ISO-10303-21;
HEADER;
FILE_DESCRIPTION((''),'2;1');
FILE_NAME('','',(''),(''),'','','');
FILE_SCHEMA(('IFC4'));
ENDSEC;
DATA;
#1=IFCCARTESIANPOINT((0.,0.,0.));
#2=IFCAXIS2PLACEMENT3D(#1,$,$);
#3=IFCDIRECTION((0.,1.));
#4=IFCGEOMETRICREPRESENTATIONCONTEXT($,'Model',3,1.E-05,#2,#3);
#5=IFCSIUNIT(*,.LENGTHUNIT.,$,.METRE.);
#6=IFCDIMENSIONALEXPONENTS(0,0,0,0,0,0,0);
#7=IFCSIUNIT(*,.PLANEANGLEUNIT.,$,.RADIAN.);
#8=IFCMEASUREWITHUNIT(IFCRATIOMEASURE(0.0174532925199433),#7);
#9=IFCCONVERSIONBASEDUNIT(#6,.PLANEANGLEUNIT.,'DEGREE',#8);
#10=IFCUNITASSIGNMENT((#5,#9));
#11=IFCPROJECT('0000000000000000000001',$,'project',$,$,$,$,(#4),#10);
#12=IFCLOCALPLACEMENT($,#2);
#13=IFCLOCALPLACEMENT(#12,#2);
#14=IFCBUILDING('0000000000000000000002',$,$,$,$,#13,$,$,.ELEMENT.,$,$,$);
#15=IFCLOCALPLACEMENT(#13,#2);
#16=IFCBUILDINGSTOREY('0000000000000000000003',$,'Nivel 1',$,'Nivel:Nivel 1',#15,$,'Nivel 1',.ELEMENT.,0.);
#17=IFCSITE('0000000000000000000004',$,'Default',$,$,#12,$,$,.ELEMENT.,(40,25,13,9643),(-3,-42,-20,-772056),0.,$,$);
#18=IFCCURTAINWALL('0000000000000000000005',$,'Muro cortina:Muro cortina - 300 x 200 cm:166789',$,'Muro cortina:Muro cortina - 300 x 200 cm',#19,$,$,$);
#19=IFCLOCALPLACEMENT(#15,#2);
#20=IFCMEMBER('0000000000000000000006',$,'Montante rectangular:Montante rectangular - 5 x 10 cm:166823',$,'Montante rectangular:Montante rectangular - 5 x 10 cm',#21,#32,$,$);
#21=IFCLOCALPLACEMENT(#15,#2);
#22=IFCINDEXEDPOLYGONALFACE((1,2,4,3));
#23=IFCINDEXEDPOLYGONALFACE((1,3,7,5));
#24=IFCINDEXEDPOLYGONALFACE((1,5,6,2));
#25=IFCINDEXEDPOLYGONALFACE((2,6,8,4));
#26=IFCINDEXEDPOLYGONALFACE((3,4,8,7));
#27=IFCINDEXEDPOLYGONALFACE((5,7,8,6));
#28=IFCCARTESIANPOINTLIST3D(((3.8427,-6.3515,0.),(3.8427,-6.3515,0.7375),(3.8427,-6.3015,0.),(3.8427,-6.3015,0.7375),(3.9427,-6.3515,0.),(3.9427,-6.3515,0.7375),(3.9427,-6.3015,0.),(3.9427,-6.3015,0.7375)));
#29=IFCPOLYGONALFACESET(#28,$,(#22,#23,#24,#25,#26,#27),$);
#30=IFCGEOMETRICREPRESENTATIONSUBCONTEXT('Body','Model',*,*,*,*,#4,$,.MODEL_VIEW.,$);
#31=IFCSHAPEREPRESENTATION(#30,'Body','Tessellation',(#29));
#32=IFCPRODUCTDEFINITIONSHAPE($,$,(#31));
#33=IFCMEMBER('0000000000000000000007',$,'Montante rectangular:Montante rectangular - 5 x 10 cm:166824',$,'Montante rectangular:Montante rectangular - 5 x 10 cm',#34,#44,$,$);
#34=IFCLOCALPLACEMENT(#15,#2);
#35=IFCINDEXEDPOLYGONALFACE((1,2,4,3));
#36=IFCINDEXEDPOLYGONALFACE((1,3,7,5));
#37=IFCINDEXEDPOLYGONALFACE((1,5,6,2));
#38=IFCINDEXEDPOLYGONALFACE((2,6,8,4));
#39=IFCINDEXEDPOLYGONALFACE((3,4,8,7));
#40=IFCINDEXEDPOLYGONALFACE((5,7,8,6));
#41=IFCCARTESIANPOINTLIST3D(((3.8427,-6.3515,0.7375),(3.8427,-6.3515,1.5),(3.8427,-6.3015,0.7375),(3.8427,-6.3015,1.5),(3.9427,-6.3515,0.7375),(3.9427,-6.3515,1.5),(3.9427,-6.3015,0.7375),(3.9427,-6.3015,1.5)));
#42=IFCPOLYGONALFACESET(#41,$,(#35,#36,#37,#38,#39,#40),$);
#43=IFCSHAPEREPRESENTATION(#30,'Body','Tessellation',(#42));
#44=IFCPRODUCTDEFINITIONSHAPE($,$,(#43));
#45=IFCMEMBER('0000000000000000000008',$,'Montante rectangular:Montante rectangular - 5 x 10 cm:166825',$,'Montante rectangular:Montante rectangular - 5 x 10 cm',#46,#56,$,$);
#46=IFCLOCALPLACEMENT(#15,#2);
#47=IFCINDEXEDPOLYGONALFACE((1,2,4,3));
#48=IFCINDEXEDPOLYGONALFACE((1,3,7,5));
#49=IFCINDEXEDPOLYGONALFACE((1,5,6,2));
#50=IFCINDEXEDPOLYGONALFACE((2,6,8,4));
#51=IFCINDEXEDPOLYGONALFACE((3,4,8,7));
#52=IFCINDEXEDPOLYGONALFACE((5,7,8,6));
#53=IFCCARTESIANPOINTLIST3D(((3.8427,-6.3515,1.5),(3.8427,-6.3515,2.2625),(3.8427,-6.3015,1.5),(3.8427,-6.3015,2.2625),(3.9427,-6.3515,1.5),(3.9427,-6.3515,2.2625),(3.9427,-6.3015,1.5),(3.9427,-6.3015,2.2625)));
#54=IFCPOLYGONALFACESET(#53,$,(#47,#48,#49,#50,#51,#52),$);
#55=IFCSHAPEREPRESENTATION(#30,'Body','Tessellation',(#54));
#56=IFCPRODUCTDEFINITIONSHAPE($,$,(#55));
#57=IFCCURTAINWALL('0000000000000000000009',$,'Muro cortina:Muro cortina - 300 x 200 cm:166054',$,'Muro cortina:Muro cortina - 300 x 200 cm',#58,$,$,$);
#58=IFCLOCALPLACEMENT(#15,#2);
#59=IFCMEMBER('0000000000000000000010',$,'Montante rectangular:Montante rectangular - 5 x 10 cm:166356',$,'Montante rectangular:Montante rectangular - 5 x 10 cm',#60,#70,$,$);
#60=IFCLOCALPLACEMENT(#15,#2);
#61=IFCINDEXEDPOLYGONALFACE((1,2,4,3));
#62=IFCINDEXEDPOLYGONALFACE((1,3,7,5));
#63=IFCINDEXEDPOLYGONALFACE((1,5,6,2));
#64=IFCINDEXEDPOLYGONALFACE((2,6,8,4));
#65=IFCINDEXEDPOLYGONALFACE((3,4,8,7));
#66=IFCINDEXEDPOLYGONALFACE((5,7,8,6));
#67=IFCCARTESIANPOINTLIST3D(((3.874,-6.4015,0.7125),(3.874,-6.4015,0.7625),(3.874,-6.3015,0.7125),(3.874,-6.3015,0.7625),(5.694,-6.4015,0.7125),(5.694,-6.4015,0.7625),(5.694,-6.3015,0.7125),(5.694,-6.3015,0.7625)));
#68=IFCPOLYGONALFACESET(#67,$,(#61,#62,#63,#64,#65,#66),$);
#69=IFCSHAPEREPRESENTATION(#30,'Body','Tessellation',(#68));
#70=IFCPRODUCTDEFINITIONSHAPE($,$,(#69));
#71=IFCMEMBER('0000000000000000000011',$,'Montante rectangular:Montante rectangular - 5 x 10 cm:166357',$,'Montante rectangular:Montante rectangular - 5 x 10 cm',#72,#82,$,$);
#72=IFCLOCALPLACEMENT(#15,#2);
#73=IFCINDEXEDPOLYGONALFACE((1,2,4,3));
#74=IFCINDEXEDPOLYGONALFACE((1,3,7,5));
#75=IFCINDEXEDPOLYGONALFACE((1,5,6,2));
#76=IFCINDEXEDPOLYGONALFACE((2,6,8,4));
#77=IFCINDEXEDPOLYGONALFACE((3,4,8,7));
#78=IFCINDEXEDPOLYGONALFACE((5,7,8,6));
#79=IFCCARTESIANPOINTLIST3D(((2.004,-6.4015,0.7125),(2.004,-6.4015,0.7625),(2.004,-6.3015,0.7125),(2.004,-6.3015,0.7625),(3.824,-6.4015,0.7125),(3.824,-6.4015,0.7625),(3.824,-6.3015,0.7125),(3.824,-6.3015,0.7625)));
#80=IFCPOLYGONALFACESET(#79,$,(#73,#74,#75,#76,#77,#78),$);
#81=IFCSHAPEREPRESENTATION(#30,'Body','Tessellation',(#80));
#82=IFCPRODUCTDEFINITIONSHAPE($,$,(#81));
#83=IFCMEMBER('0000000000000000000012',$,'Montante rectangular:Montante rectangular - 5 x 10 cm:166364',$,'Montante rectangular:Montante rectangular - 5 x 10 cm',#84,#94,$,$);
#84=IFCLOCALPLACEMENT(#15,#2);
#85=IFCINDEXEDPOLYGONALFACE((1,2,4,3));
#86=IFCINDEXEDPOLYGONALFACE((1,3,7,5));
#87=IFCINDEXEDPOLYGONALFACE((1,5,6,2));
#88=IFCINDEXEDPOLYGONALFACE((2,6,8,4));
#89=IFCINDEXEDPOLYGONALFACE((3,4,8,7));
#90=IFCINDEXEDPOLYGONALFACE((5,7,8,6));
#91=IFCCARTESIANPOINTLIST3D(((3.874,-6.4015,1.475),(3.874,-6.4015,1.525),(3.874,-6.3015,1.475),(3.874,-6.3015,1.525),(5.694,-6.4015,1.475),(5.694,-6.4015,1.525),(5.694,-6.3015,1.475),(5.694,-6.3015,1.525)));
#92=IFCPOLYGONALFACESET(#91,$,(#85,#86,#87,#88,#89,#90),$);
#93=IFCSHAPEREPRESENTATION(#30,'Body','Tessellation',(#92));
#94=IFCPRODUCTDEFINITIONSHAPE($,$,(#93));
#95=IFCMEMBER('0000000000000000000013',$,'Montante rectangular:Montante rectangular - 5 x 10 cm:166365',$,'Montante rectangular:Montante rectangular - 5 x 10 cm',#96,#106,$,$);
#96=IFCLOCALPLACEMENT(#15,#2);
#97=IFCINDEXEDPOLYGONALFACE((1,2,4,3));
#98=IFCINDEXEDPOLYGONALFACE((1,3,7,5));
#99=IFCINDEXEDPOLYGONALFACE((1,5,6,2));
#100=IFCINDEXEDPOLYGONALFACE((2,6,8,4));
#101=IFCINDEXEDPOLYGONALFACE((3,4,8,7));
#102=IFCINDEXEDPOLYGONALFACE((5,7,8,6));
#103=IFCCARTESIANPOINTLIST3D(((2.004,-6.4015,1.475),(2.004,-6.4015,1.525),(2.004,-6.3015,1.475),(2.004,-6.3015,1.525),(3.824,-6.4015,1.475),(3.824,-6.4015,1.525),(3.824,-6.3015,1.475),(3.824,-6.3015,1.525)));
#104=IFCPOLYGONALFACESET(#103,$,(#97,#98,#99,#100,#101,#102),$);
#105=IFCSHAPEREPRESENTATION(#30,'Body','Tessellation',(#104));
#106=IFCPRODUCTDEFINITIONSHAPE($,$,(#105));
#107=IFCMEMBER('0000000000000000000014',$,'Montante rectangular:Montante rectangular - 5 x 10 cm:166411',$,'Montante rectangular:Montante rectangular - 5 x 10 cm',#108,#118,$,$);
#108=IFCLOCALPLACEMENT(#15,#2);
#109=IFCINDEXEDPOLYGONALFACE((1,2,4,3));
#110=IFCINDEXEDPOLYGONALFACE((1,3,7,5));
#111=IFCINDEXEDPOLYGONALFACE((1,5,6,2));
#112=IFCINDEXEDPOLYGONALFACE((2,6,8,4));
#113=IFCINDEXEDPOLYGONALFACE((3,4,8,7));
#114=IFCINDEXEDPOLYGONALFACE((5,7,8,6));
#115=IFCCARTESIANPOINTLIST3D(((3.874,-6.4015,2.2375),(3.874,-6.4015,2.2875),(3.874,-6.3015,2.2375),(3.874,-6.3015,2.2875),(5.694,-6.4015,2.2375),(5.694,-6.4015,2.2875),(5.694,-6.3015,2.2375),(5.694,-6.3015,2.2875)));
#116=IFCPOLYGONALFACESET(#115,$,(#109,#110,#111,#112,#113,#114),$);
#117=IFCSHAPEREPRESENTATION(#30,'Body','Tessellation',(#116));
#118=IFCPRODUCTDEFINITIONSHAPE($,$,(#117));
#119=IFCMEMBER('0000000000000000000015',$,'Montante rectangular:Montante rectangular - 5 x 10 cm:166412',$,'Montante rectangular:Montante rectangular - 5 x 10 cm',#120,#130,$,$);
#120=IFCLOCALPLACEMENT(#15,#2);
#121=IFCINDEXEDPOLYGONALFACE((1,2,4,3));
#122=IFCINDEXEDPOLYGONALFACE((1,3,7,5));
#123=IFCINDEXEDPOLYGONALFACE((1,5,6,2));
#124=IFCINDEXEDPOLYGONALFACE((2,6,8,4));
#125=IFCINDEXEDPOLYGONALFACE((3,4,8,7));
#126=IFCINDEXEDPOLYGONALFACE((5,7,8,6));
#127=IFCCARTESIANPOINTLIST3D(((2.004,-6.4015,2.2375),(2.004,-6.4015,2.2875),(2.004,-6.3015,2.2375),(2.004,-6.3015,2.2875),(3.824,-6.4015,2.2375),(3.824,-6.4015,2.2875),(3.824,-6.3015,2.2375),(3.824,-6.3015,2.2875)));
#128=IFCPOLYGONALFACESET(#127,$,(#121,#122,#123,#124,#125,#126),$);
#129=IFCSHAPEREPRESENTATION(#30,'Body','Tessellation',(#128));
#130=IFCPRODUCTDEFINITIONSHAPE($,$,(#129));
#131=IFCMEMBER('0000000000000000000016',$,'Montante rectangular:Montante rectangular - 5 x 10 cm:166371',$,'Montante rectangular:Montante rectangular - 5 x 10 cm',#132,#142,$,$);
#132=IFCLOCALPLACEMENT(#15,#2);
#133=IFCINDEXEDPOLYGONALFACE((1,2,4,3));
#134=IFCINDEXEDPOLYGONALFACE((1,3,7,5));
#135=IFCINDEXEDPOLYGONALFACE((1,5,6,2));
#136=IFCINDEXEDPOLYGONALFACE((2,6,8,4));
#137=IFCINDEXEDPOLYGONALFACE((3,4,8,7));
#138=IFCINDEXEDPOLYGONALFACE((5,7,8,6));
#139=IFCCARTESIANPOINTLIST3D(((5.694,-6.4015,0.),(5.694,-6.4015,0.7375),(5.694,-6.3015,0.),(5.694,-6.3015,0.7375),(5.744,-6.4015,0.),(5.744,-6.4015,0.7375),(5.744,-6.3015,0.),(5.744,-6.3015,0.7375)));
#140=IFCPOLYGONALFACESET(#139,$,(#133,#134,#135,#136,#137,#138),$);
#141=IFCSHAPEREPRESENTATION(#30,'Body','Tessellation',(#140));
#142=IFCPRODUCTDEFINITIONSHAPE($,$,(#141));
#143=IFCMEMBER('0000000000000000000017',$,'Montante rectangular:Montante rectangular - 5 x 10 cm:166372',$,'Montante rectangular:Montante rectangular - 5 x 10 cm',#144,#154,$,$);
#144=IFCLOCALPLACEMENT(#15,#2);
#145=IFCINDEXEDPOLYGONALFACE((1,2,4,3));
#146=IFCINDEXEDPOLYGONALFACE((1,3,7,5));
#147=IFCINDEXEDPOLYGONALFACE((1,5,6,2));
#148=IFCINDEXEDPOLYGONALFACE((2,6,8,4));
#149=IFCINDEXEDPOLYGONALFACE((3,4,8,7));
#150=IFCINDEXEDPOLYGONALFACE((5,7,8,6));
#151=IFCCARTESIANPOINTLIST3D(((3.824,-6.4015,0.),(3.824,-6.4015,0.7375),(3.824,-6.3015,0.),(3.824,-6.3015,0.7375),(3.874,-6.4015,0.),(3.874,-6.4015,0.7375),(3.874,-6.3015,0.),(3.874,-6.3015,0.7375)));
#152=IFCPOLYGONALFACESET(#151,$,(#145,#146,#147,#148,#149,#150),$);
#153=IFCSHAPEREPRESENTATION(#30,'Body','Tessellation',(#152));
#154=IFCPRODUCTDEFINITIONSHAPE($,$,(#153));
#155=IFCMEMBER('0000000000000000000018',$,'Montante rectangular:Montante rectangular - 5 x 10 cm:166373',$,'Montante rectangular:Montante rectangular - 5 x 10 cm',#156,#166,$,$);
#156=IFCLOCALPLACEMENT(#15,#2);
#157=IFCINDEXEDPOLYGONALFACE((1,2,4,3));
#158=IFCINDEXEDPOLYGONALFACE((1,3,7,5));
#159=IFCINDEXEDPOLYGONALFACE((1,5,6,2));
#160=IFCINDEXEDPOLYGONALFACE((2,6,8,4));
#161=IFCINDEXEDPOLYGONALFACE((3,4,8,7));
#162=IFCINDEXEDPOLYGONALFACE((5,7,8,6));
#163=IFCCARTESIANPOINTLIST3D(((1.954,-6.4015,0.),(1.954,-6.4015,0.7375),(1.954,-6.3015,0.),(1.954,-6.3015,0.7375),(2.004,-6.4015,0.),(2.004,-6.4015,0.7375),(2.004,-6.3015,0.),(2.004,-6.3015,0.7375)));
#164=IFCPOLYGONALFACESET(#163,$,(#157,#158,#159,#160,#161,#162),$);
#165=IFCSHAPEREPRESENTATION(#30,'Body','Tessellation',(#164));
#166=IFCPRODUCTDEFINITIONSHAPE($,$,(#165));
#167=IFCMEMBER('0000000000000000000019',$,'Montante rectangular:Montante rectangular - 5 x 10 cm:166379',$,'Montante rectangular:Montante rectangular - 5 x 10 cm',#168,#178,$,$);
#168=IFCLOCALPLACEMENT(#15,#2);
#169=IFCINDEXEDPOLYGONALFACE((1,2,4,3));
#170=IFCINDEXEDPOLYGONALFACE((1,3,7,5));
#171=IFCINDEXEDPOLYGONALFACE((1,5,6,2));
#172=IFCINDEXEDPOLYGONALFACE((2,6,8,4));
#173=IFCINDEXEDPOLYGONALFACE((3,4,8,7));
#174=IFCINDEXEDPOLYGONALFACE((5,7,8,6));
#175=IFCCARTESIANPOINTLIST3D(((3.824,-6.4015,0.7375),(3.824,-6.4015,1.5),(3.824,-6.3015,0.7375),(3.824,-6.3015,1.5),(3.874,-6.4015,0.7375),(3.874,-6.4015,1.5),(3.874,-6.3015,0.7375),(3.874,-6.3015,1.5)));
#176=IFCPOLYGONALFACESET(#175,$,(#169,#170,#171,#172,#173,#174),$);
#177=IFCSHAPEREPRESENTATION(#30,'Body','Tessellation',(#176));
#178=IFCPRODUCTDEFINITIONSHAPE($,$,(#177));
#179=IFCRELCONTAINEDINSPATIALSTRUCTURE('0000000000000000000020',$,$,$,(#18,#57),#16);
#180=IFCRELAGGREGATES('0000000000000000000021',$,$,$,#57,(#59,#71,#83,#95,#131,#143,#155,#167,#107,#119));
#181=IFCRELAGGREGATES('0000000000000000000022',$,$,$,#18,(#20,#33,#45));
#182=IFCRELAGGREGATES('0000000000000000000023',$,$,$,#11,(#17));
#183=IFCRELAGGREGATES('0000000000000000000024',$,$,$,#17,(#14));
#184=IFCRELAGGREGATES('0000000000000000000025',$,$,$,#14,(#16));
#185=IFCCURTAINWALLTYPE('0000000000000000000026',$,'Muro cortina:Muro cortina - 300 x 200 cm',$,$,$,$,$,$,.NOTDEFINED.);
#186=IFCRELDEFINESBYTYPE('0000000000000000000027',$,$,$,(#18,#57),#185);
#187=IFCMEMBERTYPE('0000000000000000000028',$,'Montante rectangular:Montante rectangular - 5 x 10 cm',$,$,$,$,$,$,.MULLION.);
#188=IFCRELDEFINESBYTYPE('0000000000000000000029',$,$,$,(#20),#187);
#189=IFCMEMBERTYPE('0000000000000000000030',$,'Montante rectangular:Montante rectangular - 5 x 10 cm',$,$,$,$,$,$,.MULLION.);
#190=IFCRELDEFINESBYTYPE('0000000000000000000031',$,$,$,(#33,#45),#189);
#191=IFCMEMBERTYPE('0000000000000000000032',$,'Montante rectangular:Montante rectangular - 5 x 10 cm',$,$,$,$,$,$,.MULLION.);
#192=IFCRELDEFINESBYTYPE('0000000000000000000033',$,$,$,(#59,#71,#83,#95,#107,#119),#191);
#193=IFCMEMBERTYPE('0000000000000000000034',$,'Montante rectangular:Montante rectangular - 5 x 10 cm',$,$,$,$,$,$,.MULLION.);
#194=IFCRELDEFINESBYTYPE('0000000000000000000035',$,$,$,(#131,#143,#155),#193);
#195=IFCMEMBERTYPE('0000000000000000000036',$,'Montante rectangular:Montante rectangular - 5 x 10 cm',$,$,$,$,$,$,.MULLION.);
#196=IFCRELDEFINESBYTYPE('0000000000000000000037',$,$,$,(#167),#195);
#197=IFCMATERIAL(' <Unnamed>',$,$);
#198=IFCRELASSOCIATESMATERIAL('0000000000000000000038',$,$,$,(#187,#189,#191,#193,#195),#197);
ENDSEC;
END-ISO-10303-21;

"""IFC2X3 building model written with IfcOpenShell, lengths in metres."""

from ifc_helpers import new_model, entity, si_unit, converted_unit, direction, frame, origin, origin_2d_with_axis, place, context, subcontext, project, spatial, rectangle, extrude, source, transform, mapped, material, type_object, type_shapes, element, aggregate, save


model = new_model("IFC2X3")

# Units and contexts
model_context = context("Model", 3, precision=1e-05, world=origin(), true_north=direction((0.0, 1.0)))
body_context = subcontext(model_context, "Body", "Model", "MODEL_VIEW")
ifc_project = project(units=[si_unit("LENGTHUNIT", "METRE"), converted_unit("PLANEANGLEUNIT", "DEGREE", entity("IfcRatioMeasure", 0.0174532925199433), si_unit("PLANEANGLEUNIT", "RADIAN"), dimensions=[0, 0, 0, 0, 0, 0, 0])], contexts=[model_context])

# Site, building, storey
site_placement = place(None, origin())
site = spatial("IfcSite", under=ifc_project, at=site_placement, Name="Default", CompositionType="ELEMENT", RefLatitude=(40, 25, 13, 9643), RefLongitude=(-3, -42, -20, -772056), RefElevation=0.0)
building_placement = place(site_placement, origin())
building = spatial("IfcBuilding", under=site, at=building_placement, CompositionType="ELEMENT")
storey_placement = place(building_placement, origin())
storey = spatial("IfcBuildingStorey", under=building, at=storey_placement, Name="Nivel 1", ObjectType="Nivel:Nivel 1", LongName="Nivel 1", CompositionType="ELEMENT", Elevation=0.0)

# Curtain walls, members
curtain_wall_type = type_object("IfcCurtainWallType", Name="Muro cortina:Muro cortina - 300 x 200 cm", PredefinedType="NOTDEFINED")
curtain_wall_1_placement = place(storey_placement, origin())
curtain_wall_1 = element("IfcCurtainWall", 1, at=curtain_wall_1_placement, inside=storey, type_object=curtain_wall_type, Name="Muro cortina:Muro cortina - 300 x 200 cm:166789", ObjectType="Muro cortina:Muro cortina - 300 x 200 cm")
ifc_material_1 = material(Name=" <Unnamed>")
member_type_1 = type_object("IfcMemberType", Name="Montante rectangular:Montante rectangular - 5 x 10 cm", PredefinedType="MULLION", material=ifc_material_1)
shared_shape_1 = source(origin(), body_context, "Body", "SweptSolid", [
    extrude(rectangle(XDim=0.1, YDim=0.05, at=origin_2d_with_axis()), frame((-0.025, 0.0, -0.7375), z_axis=(0.0, 0.0, 1.0), x_axis=(0.0, -1.0, 0.0)), (0.0, 0.0, 1.0), 0.7375),
])
type_shapes(member_type_1, [shared_shape_1])
member_1_placement = place(storey_placement, frame((3.8927, -6.3515, 0.0), z_axis=(0.0, 0.0, -1.0), x_axis=(0.0, -1.0, 0.0)))
member_1 = element("IfcMember", 2, at=member_1_placement, type_object=member_type_1, Name="Montante rectangular:Montante rectangular - 5 x 10 cm:166823", ObjectType="Montante rectangular:Montante rectangular - 5 x 10 cm", context=body_context, shape_type="MappedRepresentation", body=[
    mapped(shared_shape_1, transform((0.0, 0.0, 0.0), scale=1.0)),
])
member_type_2 = type_object("IfcMemberType", Name="Montante rectangular:Montante rectangular - 5 x 10 cm", PredefinedType="MULLION", material=ifc_material_1)
shared_shape_2 = source(origin(), body_context, "Body", "SweptSolid", [
    extrude(rectangle(XDim=0.1, YDim=0.05, at=origin_2d_with_axis()), frame((-0.025, 0.0, -0.7625), z_axis=(0.0, 0.0, 1.0), x_axis=(0.0, -1.0, 0.0)), (0.0, 0.0, 1.0), 0.7625),
])
type_shapes(member_type_2, [shared_shape_2])
member_2_placement = place(storey_placement, frame((3.8927, -6.3515, 0.7375), z_axis=(0.0, 0.0, -1.0), x_axis=(0.0, -1.0, 0.0)))
member_2 = element("IfcMember", 3, at=member_2_placement, type_object=member_type_2, Name="Montante rectangular:Montante rectangular - 5 x 10 cm:166824", ObjectType="Montante rectangular:Montante rectangular - 5 x 10 cm", context=body_context, shape_type="MappedRepresentation", body=[
    mapped(shared_shape_2, transform((0.0, 0.0, 0.0), scale=1.0)),
])
member_3_placement = place(storey_placement, frame((3.8927, -6.3515, 1.5), z_axis=(0.0, 0.0, -1.0), x_axis=(0.0, -1.0, 0.0)))
member_3 = element("IfcMember", 4, at=member_3_placement, type_object=member_type_2, Name="Montante rectangular:Montante rectangular - 5 x 10 cm:166825", ObjectType="Montante rectangular:Montante rectangular - 5 x 10 cm", context=body_context, shape_type="MappedRepresentation", body=[
    mapped(shared_shape_2, transform((0.0, 0.0, 0.0), scale=1.0)),
])
curtain_wall_2_placement = place(storey_placement, origin())
curtain_wall_2 = element("IfcCurtainWall", 5, at=curtain_wall_2_placement, inside=storey, type_object=curtain_wall_type, Name="Muro cortina:Muro cortina - 300 x 200 cm:166054", ObjectType="Muro cortina:Muro cortina - 300 x 200 cm")
member_type_3 = type_object("IfcMemberType", Name="Montante rectangular:Montante rectangular - 5 x 10 cm", PredefinedType="MULLION", material=ifc_material_1)
shared_shape_3 = source(origin(), body_context, "Body", "SweptSolid", [
    extrude(rectangle(XDim=0.1, YDim=0.05, at=origin_2d_with_axis()), frame((0.0, 0.0, -1.82), z_axis=(0.0, 0.0, 1.0), x_axis=(0.0, -1.0, 0.0)), (0.0, 0.0, 1.0), 1.82),
])
type_shapes(member_type_3, [shared_shape_3])
member_4_placement = place(storey_placement, frame((3.874, -6.3515, 0.7375), z_axis=(-1.0, 0.0, 0.0), x_axis=(0.0, 0.0, 1.0)))
member_4 = element("IfcMember", 6, at=member_4_placement, type_object=member_type_3, Name="Montante rectangular:Montante rectangular - 5 x 10 cm:166356", ObjectType="Montante rectangular:Montante rectangular - 5 x 10 cm", context=body_context, shape_type="MappedRepresentation", body=[
    mapped(shared_shape_3, transform((0.0, 0.0, 0.0), scale=1.0)),
])
member_5_placement = place(storey_placement, frame((2.004, -6.3515, 0.7375), z_axis=(-1.0, 0.0, 0.0), x_axis=(0.0, 0.0, 1.0)))
member_5 = element("IfcMember", 7, at=member_5_placement, type_object=member_type_3, Name="Montante rectangular:Montante rectangular - 5 x 10 cm:166357", ObjectType="Montante rectangular:Montante rectangular - 5 x 10 cm", context=body_context, shape_type="MappedRepresentation", body=[
    mapped(shared_shape_3, transform((0.0, 0.0, 0.0), scale=1.0)),
])
member_6_placement = place(storey_placement, frame((3.874, -6.3515, 1.5), z_axis=(-1.0, 0.0, 0.0), x_axis=(0.0, 0.0, 1.0)))
member_6 = element("IfcMember", 8, at=member_6_placement, type_object=member_type_3, Name="Montante rectangular:Montante rectangular - 5 x 10 cm:166364", ObjectType="Montante rectangular:Montante rectangular - 5 x 10 cm", context=body_context, shape_type="MappedRepresentation", body=[
    mapped(shared_shape_3, transform((0.0, 0.0, 0.0), scale=1.0)),
])
member_7_placement = place(storey_placement, frame((2.004, -6.3515, 1.5), z_axis=(-1.0, 0.0, 0.0), x_axis=(0.0, 0.0, 1.0)))
member_7 = element("IfcMember", 9, at=member_7_placement, type_object=member_type_3, Name="Montante rectangular:Montante rectangular - 5 x 10 cm:166365", ObjectType="Montante rectangular:Montante rectangular - 5 x 10 cm", context=body_context, shape_type="MappedRepresentation", body=[
    mapped(shared_shape_3, transform((0.0, 0.0, 0.0), scale=1.0)),
])
member_8_placement = place(storey_placement, frame((3.874, -6.3515, 2.2625), z_axis=(-1.0, 0.0, 0.0), x_axis=(0.0, 0.0, 1.0)))
member_8 = element("IfcMember", 10, at=member_8_placement, type_object=member_type_3, Name="Montante rectangular:Montante rectangular - 5 x 10 cm:166411", ObjectType="Montante rectangular:Montante rectangular - 5 x 10 cm", context=body_context, shape_type="MappedRepresentation", body=[
    mapped(shared_shape_3, transform((0.0, 0.0, 0.0), scale=1.0)),
])
member_9_placement = place(storey_placement, frame((2.004, -6.3515, 2.2625), z_axis=(-1.0, 0.0, 0.0), x_axis=(0.0, 0.0, 1.0)))
member_9 = element("IfcMember", 11, at=member_9_placement, type_object=member_type_3, Name="Montante rectangular:Montante rectangular - 5 x 10 cm:166412", ObjectType="Montante rectangular:Montante rectangular - 5 x 10 cm", context=body_context, shape_type="MappedRepresentation", body=[
    mapped(shared_shape_3, transform((0.0, 0.0, 0.0), scale=1.0)),
])
member_type_4 = type_object("IfcMemberType", Name="Montante rectangular:Montante rectangular - 5 x 10 cm", PredefinedType="MULLION", material=ifc_material_1)
shared_shape_4 = source(origin(), body_context, "Body", "SweptSolid", [
    extrude(rectangle(XDim=0.1, YDim=0.05, at=origin_2d_with_axis()), frame((0.0, 0.0, -0.7375), z_axis=(0.0, 0.0, 1.0), x_axis=(0.0, -1.0, 0.0)), (0.0, 0.0, 1.0), 0.7375),
])
type_shapes(member_type_4, [shared_shape_4])
member_10_placement = place(storey_placement, frame((5.719, -6.3515, 0.0), z_axis=(0.0, 0.0, -1.0), x_axis=(-1.0, 0.0, 0.0)))
member_10 = element("IfcMember", 12, at=member_10_placement, type_object=member_type_4, Name="Montante rectangular:Montante rectangular - 5 x 10 cm:166371", ObjectType="Montante rectangular:Montante rectangular - 5 x 10 cm", context=body_context, shape_type="MappedRepresentation", body=[
    mapped(shared_shape_4, transform((0.0, 0.0, 0.0), scale=1.0)),
])
member_11_placement = place(storey_placement, frame((3.849, -6.3515, 0.0), z_axis=(0.0, 0.0, -1.0), x_axis=(-1.0, 0.0, 0.0)))
member_11 = element("IfcMember", 13, at=member_11_placement, type_object=member_type_4, Name="Montante rectangular:Montante rectangular - 5 x 10 cm:166372", ObjectType="Montante rectangular:Montante rectangular - 5 x 10 cm", context=body_context, shape_type="MappedRepresentation", body=[
    mapped(shared_shape_4, transform((0.0, 0.0, 0.0), scale=1.0)),
])
member_12_placement = place(storey_placement, frame((1.979, -6.3515, 0.0), z_axis=(0.0, 0.0, -1.0), x_axis=(-1.0, 0.0, 0.0)))
member_12 = element("IfcMember", 14, at=member_12_placement, type_object=member_type_4, Name="Montante rectangular:Montante rectangular - 5 x 10 cm:166373", ObjectType="Montante rectangular:Montante rectangular - 5 x 10 cm", context=body_context, shape_type="MappedRepresentation", body=[
    mapped(shared_shape_4, transform((0.0, 0.0, 0.0), scale=1.0)),
])
member_type_5 = type_object("IfcMemberType", Name="Montante rectangular:Montante rectangular - 5 x 10 cm", PredefinedType="MULLION", material=ifc_material_1)
shared_shape_5 = source(origin(), body_context, "Body", "SweptSolid", [
    extrude(rectangle(XDim=0.1, YDim=0.05, at=origin_2d_with_axis()), frame((0.0, 0.0, -0.7625), z_axis=(0.0, 0.0, 1.0), x_axis=(0.0, -1.0, 0.0)), (0.0, 0.0, 1.0), 0.7625),
])
type_shapes(member_type_5, [shared_shape_5])
member_13_placement = place(storey_placement, frame((3.849, -6.3515, 0.7375), z_axis=(0.0, 0.0, -1.0), x_axis=(-1.0, 0.0, 0.0)))
member_13 = element("IfcMember", 15, at=member_13_placement, type_object=member_type_5, Name="Montante rectangular:Montante rectangular - 5 x 10 cm:166379", ObjectType="Montante rectangular:Montante rectangular - 5 x 10 cm", context=body_context, shape_type="MappedRepresentation", body=[
    mapped(shared_shape_5, transform((0.0, 0.0, 0.0), scale=1.0)),
])

aggregate(curtain_wall_2, [member_4, member_5, member_6, member_7, member_10, member_11, member_12, member_13, member_8, member_9])
aggregate(curtain_wall_1, [member_1, member_2, member_3])

save(model, "model.ifc")
